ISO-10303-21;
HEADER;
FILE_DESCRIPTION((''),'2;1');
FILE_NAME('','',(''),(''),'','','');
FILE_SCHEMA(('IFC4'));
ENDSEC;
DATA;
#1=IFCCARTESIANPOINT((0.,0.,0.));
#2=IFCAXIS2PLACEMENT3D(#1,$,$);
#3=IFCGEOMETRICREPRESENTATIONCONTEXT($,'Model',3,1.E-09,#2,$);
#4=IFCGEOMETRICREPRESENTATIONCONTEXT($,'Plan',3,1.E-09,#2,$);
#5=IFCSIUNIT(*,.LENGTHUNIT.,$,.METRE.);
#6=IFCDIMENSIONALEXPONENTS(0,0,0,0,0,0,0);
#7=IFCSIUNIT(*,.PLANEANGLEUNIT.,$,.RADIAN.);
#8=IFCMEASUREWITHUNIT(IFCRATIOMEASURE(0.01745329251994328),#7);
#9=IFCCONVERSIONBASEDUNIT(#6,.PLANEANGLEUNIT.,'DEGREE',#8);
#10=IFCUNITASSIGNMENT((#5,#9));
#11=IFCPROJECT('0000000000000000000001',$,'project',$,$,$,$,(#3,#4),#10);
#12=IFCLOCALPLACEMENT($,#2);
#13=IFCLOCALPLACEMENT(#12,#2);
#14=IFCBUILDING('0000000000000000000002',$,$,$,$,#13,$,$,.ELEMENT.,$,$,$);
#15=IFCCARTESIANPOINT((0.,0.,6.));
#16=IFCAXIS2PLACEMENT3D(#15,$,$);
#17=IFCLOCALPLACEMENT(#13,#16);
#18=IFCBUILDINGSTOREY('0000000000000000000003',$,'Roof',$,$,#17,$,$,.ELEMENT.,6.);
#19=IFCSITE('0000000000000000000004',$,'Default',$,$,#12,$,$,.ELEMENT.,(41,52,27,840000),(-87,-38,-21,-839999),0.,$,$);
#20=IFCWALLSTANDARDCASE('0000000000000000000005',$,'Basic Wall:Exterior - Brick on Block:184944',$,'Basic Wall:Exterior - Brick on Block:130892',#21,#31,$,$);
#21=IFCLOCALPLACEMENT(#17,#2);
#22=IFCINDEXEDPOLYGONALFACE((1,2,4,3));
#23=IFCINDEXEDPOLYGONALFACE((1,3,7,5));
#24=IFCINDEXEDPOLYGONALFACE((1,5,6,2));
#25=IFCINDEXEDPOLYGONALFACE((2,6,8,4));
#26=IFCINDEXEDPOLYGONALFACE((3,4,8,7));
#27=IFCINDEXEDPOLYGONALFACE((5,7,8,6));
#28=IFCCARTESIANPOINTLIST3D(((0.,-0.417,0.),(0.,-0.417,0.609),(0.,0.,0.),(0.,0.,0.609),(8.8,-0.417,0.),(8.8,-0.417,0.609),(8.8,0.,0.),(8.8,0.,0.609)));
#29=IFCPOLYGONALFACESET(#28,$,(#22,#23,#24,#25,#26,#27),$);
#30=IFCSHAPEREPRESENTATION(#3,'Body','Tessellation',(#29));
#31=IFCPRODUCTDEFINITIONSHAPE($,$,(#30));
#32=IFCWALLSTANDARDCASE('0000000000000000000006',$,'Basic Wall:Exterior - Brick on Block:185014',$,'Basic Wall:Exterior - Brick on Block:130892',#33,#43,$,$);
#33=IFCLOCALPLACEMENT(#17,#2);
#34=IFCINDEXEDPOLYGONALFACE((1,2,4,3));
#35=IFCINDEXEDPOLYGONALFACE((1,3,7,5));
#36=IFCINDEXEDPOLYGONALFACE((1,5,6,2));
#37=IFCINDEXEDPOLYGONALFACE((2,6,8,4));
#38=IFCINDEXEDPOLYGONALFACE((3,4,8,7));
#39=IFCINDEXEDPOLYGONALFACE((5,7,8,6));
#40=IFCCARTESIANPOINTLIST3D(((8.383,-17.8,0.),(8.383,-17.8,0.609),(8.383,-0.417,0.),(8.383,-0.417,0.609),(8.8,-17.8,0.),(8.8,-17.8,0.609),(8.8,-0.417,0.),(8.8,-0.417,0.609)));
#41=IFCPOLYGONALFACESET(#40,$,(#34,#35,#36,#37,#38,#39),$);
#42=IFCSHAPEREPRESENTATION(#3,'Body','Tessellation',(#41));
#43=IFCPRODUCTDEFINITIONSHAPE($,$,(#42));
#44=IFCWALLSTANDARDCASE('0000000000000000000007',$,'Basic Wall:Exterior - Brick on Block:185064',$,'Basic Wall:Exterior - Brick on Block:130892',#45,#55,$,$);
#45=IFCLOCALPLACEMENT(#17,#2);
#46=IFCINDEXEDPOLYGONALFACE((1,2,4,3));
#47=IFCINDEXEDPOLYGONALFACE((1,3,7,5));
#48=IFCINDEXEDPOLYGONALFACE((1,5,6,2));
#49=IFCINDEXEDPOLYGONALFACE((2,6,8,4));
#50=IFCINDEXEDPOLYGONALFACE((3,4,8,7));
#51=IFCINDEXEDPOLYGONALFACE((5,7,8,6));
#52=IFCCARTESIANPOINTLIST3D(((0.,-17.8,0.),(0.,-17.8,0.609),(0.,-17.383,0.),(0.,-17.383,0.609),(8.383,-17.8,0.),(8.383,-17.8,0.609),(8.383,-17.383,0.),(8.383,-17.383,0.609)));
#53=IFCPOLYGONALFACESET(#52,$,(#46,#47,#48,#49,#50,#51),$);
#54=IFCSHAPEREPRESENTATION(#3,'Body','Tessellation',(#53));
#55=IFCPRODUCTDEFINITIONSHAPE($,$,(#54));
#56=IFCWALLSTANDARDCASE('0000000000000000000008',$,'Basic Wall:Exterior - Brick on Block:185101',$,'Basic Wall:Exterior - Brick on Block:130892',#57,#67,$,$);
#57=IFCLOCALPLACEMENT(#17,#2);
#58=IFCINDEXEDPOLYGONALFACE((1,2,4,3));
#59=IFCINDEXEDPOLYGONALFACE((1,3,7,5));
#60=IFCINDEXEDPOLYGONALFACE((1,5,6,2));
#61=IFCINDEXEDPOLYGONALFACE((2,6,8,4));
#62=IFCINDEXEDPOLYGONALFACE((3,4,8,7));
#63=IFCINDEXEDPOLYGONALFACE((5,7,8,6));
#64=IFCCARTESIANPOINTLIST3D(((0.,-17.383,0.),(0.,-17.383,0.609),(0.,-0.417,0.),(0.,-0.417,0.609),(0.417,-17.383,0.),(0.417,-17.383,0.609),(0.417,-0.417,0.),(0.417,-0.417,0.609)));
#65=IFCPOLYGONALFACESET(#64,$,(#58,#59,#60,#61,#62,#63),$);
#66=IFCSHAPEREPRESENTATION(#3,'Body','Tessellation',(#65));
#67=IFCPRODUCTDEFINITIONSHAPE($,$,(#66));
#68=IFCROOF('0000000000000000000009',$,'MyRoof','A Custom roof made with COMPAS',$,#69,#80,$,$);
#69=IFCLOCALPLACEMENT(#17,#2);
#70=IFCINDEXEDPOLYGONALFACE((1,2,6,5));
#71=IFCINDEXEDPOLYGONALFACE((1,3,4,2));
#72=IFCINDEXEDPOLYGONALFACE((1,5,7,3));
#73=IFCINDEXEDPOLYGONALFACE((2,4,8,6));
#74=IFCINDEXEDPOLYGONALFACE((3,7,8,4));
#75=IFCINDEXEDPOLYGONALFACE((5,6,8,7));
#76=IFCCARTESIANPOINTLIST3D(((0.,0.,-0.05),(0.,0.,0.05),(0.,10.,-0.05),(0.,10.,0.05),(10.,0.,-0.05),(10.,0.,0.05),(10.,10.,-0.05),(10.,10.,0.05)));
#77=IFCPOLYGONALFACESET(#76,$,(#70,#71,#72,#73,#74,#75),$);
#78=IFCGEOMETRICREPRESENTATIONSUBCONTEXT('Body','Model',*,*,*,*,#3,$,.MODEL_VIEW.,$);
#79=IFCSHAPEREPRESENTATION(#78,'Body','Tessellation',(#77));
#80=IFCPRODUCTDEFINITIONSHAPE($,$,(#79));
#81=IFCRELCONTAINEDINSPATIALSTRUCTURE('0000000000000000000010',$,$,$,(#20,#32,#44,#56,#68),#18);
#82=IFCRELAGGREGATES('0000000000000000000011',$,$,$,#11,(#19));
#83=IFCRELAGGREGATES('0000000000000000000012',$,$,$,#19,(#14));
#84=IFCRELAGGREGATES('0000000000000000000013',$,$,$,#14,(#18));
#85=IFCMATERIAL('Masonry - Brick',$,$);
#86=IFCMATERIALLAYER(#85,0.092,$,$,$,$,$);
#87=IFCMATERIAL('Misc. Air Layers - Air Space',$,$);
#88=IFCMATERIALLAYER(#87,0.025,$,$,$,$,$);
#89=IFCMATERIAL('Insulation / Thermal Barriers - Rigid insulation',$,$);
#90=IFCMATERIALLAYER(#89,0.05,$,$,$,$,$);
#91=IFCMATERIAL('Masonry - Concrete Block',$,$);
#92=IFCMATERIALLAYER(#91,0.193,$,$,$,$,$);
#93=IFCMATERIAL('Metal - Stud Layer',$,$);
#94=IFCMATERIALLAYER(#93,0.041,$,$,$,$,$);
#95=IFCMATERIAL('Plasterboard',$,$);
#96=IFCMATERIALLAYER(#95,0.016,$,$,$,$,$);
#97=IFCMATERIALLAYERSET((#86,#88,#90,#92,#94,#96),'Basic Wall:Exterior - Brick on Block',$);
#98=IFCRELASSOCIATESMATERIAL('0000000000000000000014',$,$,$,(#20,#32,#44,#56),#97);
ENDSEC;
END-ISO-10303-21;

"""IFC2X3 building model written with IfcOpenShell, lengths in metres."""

from ifc_helpers import new_model, entity, si_unit, converted_unit, frame, frame_2d, origin, place, context, subcontext, project, spatial, rectangle, extrude, material, layer, layer_set, layer_usage, element, save


model = new_model("IFC2X3")

# Units and contexts
model_context = context("Model", 3, precision=1e-09, world=origin())
plan_context = context("Plan", 3, precision=1e-09, world=origin())
body_context = subcontext(model_context, "Body", "Model", "MODEL_VIEW")
ifc_project = project(units=[si_unit("LENGTHUNIT", "METRE"), converted_unit("PLANEANGLEUNIT", "DEGREE", entity("IfcRatioMeasure", 0.01745329251994328), si_unit("PLANEANGLEUNIT", "RADIAN"), dimensions=[0, 0, 0, 0, 0, 0, 0])], contexts=[model_context, plan_context])

# Site, building, storey
site_placement = place(None, origin())
site = spatial("IfcSite", under=ifc_project, at=site_placement, Name="Default", CompositionType="ELEMENT", RefLatitude=(41, 52, 27, 840000), RefLongitude=(-87, -38, -21, -839999), RefElevation=0.0)
building_placement = place(site_placement, origin())
building = spatial("IfcBuilding", under=site, at=building_placement, CompositionType="ELEMENT")
storey_placement = place(building_placement, frame((0.0, 0.0, 6.0)))
storey = spatial("IfcBuildingStorey", under=building, at=storey_placement, Name="Roof", CompositionType="ELEMENT", Elevation=6.0)

# Walls
ifc_material_1 = material(Name="Masonry - Brick")
ifc_layer_1 = layer(ifc_material_1, 0.092)
ifc_material_2 = material(Name="Misc. Air Layers - Air Space")
ifc_layer_2 = layer(ifc_material_2, 0.025)
ifc_material_3 = material(Name="Insulation / Thermal Barriers - Rigid insulation")
ifc_layer_3 = layer(ifc_material_3, 0.05)
ifc_material_4 = material(Name="Masonry - Concrete Block")
ifc_layer_4 = layer(ifc_material_4, 0.193)
ifc_material_5 = material(Name="Metal - Stud Layer")
ifc_layer_5 = layer(ifc_material_5, 0.041)
ifc_material_6 = material(Name="Plasterboard")
ifc_layer_6 = layer(ifc_material_6, 0.016)
ifc_layer_set = layer_set([ifc_layer_1, ifc_layer_2, ifc_layer_3, ifc_layer_4, ifc_layer_5, ifc_layer_6], Name="Basic Wall:Exterior - Brick on Block")
ifc_layer_usage_1 = layer_usage(ifc_layer_set, "AXIS2", "NEGATIVE", 0.2085)
wall_1_placement = place(storey_placement, frame((0.0, -0.2085, 0.0)))
element("IfcWallStandardCase", 1, at=wall_1_placement, inside=storey, material=ifc_layer_usage_1, Name="Basic Wall:Exterior - Brick on Block:184944", ObjectType="Basic Wall:Exterior - Brick on Block:130892", context=model_context, shape_type="SweptSolid", body=[
    extrude(rectangle(XDim=8.8, YDim=0.417, at=frame_2d((4.4, 0.0), x_axis=(-1.0, 0.0))), origin(), (0.0, 0.0, 1.0), 0.609),
])
ifc_layer_usage_2 = layer_usage(ifc_layer_set, "AXIS2", "NEGATIVE", 0.2085)
wall_2_placement = place(storey_placement, frame((8.5915, -0.417, 0.0), z_axis=(0.0, 0.0, 1.0), x_axis=(0.0, -1.0, 0.0)))
element("IfcWallStandardCase", 2, at=wall_2_placement, inside=storey, material=ifc_layer_usage_2, Name="Basic Wall:Exterior - Brick on Block:185014", ObjectType="Basic Wall:Exterior - Brick on Block:130892", context=model_context, shape_type="SweptSolid", body=[
    extrude(rectangle(XDim=17.383, YDim=0.417, at=frame_2d((8.6915, 0.0), x_axis=(-1.0, 0.0))), origin(), (0.0, 0.0, 1.0), 0.609),
])
ifc_layer_usage_3 = layer_usage(ifc_layer_set, "AXIS2", "NEGATIVE", 0.2085)
wall_3_placement = place(storey_placement, frame((8.383, -17.5915, 0.0), z_axis=(0.0, 0.0, 1.0), x_axis=(-1.0, 0.0, 0.0)))
element("IfcWallStandardCase", 3, at=wall_3_placement, inside=storey, material=ifc_layer_usage_3, Name="Basic Wall:Exterior - Brick on Block:185064", ObjectType="Basic Wall:Exterior - Brick on Block:130892", context=model_context, shape_type="SweptSolid", body=[
    extrude(rectangle(XDim=8.383, YDim=0.417, at=frame_2d((4.1915, 0.0), x_axis=(-1.0, 0.0))), origin(), (0.0, 0.0, 1.0), 0.609),
])
ifc_layer_usage_4 = layer_usage(ifc_layer_set, "AXIS2", "NEGATIVE", 0.2085)
wall_4_placement = place(storey_placement, frame((0.2085, -17.383, 0.0), z_axis=(0.0, 0.0, 1.0), x_axis=(0.0, 1.0, 0.0)))
element("IfcWallStandardCase", 4, at=wall_4_placement, inside=storey, material=ifc_layer_usage_4, Name="Basic Wall:Exterior - Brick on Block:185101", ObjectType="Basic Wall:Exterior - Brick on Block:130892", context=model_context, shape_type="SweptSolid", body=[
    extrude(rectangle(XDim=16.966, YDim=0.417, at=frame_2d((8.483, 0.0), x_axis=(-1.0, 0.0))), origin(), (0.0, 0.0, 1.0), 0.609),
])

# Roof
roof_placement = place(None, frame((5.0, 5.0, 6.0), z_axis=(0.0, 0.0, 1.0), x_axis=(1.0, 0.0, 0.0)))
element("IfcRoof", 5, at=roof_placement, inside=storey, Name="MyRoof", Description="A Custom roof made with COMPAS", context=body_context, shape_type="SolidModel", body=[
    entity("IfcBlock", entity("IfcAxis2Placement3D", entity("IfcCartesianPoint", [-5.0, -5.0, -0.05]), entity("IfcDirection", [0.0, 0.0, 1.0]), entity("IfcDirection", [1.0, 0.0, 0.0])), 10.0, 10.0, 0.1),
])

save(model, "model.ifc")
